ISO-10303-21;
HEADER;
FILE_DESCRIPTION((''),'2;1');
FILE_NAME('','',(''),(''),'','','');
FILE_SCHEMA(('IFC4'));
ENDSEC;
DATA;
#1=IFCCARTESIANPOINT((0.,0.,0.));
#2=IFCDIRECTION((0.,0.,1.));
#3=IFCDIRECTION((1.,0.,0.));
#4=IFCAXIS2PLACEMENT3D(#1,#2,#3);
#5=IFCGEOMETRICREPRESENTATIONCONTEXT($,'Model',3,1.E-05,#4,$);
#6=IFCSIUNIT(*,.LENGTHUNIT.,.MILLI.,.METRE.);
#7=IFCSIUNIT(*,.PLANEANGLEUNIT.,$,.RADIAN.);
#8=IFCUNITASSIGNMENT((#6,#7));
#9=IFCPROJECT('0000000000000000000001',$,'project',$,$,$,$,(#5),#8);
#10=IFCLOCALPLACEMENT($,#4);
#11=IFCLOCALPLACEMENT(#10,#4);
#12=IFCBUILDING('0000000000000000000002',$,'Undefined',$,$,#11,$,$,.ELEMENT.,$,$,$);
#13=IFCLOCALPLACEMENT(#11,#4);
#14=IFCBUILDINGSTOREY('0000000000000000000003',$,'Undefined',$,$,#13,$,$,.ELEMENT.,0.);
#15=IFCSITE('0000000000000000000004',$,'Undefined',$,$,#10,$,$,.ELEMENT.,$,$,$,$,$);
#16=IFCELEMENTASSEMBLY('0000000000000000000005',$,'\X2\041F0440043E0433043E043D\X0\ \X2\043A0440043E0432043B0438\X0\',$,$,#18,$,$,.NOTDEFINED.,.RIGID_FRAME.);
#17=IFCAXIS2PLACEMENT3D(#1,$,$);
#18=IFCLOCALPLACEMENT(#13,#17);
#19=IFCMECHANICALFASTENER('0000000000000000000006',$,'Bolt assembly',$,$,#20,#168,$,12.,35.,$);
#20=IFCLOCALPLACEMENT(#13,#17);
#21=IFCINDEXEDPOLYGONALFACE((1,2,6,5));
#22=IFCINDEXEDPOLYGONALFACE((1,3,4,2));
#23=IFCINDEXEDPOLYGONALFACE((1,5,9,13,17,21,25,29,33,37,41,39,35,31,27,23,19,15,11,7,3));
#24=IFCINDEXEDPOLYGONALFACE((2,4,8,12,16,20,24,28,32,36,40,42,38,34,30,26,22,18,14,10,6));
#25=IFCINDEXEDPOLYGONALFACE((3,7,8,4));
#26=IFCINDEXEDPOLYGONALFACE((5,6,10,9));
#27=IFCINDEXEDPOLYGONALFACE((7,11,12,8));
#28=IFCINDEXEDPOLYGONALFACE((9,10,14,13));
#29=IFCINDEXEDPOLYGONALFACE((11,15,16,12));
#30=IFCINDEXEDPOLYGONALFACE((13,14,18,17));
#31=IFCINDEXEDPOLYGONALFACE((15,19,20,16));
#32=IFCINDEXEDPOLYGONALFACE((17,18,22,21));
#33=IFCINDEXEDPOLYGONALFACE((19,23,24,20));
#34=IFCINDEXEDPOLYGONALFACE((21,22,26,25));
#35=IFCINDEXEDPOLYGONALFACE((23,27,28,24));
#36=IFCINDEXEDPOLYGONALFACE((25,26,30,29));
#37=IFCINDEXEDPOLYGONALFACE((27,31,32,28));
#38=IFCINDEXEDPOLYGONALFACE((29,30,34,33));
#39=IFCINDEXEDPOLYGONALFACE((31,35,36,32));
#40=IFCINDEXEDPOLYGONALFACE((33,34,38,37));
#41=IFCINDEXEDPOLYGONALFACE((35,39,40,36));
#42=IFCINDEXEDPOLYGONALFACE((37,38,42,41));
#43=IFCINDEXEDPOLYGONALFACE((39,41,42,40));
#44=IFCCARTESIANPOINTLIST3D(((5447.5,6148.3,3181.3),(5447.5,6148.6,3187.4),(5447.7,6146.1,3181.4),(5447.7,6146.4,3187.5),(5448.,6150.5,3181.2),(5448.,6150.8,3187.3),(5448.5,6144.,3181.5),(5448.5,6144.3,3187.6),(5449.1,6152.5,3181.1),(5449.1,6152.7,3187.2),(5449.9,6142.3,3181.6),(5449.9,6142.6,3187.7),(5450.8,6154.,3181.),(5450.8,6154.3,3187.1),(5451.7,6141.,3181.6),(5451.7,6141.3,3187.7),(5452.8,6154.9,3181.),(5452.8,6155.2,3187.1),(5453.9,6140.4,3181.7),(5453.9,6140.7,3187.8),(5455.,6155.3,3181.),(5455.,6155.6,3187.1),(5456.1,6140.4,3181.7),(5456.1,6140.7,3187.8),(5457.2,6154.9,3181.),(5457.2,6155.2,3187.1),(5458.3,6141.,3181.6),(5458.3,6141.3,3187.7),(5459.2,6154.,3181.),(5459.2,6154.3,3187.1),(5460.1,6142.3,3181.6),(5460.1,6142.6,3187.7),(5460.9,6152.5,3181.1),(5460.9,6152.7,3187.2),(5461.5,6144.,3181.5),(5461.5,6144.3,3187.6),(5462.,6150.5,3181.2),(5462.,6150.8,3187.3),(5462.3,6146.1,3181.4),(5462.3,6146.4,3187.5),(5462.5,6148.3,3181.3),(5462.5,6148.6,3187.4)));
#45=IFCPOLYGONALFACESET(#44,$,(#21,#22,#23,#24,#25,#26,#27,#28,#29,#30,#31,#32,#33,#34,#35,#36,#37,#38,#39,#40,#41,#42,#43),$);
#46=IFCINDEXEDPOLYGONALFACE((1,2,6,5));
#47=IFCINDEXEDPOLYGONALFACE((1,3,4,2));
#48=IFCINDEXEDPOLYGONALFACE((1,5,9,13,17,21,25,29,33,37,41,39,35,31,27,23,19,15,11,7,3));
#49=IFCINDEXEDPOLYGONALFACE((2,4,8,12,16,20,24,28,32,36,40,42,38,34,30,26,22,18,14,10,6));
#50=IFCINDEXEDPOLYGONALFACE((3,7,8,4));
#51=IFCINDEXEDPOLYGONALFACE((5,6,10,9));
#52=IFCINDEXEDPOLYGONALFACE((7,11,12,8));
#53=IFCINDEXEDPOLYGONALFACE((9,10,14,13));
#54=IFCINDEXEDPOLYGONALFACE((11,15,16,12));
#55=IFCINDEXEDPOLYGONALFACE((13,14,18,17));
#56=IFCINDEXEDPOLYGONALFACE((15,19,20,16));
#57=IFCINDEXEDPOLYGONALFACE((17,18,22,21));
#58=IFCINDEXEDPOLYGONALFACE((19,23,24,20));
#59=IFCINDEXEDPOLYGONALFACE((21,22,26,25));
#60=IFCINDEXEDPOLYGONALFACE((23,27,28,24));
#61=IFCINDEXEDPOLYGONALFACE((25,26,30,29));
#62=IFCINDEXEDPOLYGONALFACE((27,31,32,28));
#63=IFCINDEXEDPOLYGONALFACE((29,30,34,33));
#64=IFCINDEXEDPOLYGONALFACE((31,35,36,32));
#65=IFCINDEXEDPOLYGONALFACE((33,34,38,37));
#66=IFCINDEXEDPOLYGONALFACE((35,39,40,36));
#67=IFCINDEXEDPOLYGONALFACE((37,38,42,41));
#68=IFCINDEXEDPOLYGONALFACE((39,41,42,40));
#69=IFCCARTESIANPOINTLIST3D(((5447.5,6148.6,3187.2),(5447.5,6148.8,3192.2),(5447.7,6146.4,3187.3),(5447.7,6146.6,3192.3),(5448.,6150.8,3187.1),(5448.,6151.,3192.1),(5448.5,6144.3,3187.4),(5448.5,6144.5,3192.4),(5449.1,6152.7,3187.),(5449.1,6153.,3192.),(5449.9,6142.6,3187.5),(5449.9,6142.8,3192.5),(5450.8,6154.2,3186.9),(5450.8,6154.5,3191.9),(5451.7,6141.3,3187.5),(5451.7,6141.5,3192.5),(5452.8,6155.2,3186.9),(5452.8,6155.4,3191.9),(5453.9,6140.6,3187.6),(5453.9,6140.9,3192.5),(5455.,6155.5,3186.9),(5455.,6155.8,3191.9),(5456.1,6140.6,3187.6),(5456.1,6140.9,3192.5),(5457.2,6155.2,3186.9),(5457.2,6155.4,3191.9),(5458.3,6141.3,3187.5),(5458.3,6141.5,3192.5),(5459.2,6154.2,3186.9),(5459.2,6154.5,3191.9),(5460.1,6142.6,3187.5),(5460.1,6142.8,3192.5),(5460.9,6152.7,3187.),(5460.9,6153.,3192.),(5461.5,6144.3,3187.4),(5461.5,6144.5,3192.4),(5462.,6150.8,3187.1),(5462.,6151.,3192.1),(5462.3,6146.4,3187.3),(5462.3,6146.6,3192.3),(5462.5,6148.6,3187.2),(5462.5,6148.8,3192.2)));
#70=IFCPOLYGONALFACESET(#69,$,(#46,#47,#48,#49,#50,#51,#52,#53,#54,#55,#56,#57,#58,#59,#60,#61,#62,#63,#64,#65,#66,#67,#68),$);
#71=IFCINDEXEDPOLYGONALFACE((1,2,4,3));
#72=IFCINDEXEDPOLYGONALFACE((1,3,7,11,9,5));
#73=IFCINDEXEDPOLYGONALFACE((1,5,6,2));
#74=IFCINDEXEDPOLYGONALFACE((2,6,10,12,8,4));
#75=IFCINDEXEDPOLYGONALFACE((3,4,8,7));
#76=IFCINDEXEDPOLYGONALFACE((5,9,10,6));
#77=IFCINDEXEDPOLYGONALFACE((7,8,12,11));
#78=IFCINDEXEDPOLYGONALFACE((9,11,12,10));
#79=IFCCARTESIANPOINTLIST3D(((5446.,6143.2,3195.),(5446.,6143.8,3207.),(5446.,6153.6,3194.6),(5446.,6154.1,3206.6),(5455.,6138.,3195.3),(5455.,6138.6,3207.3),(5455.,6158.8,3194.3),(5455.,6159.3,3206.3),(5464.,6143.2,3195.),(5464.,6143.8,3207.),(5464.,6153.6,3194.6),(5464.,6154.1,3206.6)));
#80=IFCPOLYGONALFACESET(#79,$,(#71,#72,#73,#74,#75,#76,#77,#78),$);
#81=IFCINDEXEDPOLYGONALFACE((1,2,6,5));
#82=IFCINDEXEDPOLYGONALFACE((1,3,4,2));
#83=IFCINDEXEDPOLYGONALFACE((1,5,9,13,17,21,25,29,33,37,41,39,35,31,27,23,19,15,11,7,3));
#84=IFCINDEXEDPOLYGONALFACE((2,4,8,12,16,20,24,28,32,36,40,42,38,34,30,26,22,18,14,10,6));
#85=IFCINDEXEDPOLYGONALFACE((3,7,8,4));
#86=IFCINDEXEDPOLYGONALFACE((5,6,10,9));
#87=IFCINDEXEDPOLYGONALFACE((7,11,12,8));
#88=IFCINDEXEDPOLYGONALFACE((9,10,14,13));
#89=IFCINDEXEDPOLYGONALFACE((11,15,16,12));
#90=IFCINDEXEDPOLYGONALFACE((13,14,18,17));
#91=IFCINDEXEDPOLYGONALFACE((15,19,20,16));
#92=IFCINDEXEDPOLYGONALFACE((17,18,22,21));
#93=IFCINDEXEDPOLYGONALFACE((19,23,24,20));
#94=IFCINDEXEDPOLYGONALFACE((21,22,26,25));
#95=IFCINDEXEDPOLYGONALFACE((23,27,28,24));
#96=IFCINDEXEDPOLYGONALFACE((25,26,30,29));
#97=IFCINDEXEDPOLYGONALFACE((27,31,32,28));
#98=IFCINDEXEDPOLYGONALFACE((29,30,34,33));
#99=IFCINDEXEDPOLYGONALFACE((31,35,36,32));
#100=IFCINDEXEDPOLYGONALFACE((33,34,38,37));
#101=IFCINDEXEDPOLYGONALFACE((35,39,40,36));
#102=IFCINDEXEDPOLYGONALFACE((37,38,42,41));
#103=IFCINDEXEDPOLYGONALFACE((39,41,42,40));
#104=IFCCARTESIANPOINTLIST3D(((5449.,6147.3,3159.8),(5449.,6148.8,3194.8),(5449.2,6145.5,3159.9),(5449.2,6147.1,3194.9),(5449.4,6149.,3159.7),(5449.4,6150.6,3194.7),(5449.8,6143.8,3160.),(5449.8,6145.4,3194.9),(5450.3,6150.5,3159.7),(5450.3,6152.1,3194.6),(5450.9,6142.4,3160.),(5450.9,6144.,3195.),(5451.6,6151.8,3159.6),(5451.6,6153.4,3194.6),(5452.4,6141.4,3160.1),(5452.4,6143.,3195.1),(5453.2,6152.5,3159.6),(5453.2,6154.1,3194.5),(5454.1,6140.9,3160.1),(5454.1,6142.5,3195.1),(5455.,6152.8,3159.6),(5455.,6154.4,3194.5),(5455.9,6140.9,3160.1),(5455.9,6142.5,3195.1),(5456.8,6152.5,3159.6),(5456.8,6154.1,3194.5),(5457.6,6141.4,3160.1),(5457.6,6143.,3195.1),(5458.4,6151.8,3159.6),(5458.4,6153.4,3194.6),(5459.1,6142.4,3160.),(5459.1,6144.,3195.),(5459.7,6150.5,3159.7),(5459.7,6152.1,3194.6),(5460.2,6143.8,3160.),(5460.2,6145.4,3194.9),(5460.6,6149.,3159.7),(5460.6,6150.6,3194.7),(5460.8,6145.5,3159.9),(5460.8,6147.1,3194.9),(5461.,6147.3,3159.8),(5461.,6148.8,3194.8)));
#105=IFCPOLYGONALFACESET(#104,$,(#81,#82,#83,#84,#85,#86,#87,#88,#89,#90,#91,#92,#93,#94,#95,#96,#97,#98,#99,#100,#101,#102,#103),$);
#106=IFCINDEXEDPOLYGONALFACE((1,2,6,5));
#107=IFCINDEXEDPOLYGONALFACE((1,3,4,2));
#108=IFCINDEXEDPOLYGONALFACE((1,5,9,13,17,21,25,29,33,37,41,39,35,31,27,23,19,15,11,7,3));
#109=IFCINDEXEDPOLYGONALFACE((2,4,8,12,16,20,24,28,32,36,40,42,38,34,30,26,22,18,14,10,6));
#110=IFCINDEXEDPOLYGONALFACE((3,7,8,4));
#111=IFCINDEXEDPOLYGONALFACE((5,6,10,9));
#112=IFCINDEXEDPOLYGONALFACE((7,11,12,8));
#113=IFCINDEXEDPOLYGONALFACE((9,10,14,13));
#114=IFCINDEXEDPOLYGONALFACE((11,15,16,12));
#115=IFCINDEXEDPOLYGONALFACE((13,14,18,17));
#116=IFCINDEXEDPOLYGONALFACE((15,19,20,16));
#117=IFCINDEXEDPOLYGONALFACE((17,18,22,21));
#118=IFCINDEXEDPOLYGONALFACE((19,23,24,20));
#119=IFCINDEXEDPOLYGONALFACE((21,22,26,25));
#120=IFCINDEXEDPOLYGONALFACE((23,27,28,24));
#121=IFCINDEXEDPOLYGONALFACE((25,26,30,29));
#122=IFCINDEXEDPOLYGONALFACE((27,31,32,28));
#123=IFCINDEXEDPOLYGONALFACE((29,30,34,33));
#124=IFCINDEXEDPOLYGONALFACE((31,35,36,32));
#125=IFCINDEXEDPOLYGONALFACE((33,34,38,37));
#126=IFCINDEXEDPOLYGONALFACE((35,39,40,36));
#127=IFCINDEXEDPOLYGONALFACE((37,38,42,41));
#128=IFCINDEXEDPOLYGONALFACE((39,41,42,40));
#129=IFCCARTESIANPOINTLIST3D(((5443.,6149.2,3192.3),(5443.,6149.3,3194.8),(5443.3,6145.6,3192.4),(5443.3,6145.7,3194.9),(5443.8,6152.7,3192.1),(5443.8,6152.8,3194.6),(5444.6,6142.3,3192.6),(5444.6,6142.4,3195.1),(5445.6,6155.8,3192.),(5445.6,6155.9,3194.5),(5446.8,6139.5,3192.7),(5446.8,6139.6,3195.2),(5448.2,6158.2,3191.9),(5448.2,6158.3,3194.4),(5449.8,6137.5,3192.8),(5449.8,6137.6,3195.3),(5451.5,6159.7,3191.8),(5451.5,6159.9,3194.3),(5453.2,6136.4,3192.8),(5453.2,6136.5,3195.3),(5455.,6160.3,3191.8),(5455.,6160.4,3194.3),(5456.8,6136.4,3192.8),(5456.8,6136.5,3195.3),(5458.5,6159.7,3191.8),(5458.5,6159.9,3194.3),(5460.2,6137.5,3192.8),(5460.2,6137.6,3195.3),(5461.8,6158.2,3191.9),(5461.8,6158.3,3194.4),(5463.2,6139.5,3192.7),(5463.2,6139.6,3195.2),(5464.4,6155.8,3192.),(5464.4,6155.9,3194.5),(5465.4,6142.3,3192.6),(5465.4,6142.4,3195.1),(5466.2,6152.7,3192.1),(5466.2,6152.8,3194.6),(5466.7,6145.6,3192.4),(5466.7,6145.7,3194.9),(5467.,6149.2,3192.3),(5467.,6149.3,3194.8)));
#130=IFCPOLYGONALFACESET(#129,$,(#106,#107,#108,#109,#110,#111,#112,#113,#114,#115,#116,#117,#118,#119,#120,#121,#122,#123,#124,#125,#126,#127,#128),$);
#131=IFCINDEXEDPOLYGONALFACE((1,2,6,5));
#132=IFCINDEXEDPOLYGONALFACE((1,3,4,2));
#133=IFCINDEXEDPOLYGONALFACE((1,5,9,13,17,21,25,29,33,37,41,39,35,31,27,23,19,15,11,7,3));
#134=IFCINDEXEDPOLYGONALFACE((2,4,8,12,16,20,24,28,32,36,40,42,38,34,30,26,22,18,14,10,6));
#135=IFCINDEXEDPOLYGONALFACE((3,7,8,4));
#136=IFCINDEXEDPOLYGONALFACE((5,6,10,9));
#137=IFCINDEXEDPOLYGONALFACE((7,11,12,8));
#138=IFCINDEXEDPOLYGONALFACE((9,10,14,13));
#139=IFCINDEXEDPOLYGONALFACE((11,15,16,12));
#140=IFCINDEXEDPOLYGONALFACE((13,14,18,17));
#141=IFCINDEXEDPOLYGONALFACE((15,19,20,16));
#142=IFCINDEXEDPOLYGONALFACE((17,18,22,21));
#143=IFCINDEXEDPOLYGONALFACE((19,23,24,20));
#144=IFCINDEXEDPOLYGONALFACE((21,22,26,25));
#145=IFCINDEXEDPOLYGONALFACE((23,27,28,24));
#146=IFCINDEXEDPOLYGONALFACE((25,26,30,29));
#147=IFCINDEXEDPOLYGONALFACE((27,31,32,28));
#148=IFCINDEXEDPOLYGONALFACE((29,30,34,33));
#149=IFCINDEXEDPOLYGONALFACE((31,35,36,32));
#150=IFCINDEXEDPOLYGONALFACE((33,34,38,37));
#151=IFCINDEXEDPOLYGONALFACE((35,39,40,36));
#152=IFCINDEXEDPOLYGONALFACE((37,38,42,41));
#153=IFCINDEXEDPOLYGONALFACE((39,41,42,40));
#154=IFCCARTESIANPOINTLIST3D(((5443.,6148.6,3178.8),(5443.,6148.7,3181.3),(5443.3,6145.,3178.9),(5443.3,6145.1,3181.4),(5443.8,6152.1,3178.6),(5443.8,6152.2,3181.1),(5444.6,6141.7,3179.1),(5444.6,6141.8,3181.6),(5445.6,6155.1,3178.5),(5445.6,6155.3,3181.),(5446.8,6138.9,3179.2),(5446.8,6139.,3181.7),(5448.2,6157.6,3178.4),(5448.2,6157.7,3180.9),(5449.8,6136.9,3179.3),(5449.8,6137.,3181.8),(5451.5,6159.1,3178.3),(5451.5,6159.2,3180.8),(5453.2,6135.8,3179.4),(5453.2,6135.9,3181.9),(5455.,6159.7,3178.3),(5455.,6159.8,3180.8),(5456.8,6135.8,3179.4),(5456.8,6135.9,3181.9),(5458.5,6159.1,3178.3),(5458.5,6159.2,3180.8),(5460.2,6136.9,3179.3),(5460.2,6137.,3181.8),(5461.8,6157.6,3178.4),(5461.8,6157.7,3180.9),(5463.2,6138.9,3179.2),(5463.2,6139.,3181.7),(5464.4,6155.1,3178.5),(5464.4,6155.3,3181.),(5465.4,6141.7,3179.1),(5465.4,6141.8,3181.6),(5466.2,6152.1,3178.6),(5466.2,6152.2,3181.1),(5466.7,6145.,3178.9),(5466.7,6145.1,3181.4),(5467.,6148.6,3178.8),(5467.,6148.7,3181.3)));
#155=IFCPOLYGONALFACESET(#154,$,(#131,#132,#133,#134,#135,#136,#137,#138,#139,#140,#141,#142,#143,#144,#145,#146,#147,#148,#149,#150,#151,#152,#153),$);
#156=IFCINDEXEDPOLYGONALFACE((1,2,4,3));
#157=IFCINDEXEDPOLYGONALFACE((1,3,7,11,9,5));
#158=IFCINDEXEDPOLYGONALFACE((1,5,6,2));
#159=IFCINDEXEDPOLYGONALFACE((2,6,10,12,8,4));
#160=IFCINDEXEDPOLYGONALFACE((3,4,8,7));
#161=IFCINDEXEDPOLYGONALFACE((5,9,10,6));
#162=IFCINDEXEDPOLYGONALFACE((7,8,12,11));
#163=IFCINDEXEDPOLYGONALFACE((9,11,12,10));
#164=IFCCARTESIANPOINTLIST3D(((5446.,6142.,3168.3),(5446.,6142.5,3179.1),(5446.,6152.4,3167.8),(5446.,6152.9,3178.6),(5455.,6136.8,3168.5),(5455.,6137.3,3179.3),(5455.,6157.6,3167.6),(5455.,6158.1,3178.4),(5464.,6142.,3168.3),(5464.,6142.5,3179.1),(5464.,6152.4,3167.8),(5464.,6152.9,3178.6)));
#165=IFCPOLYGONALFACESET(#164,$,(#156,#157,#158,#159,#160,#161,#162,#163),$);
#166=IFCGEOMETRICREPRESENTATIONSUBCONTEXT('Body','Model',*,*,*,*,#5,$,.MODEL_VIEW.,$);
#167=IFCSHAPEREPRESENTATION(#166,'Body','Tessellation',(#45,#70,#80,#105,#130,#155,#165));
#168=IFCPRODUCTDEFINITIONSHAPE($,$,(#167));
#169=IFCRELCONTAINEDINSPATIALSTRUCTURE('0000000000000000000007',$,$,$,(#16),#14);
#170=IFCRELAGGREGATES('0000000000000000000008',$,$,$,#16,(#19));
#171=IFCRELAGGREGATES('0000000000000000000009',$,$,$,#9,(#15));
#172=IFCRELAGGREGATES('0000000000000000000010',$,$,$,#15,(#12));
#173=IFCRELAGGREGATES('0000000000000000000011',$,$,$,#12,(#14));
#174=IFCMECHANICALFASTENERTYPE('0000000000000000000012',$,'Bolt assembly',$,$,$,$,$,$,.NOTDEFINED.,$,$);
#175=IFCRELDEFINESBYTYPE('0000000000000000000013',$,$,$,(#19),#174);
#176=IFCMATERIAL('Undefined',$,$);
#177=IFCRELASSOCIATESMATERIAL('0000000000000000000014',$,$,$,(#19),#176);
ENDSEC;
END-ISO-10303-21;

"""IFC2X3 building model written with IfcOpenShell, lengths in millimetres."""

from ifc_helpers import new_model, si_unit, frame, origin_with_axes, origin_2d_with_axis, place, context, subcontext, project, spatial, polyline, circle, outline, extrude, source, transform, mapped, material, type_object, element, aggregate, save


model = new_model("IFC2X3")

# Units and contexts
model_context = context("Model", 3, precision=1e-05, world=origin_with_axes())
body_context = subcontext(model_context, "Body", "Model", "MODEL_VIEW")
ifc_project = project(units=[si_unit("LENGTHUNIT", "METRE", prefix="MILLI"), si_unit("PLANEANGLEUNIT", "RADIAN")], contexts=[model_context])

# Site, building, storey
site_placement = place(None, origin_with_axes())
site = spatial("IfcSite", under=ifc_project, at=site_placement, Name="Undefined", CompositionType="ELEMENT")
building_placement = place(site_placement, origin_with_axes())
building = spatial("IfcBuilding", under=site, at=building_placement, Name="Undefined", CompositionType="ELEMENT")
storey_placement = place(building_placement, origin_with_axes())
storey = spatial("IfcBuildingStorey", under=building, at=storey_placement, Name="Undefined", CompositionType="ELEMENT", Elevation=0.0)

# Element assembly
assembly_1_placement = place(storey_placement, origin_with_axes())
assembly_1 = element("IfcElementAssembly", 1, at=assembly_1_placement, inside=storey, Name="Прогон кровли", AssemblyPlace="NOTDEFINED", PredefinedType="RIGID_FRAME")

# Mechanical fastener
ifc_material_1 = material(Name="Undefined")
mechanical_fastener_type = type_object("IfcMechanicalFastenerType", Name="Bolt assembly")
shared_shape_1 = source(origin_with_axes(), body_context, "Body", "SweptSolid", [
    extrude(circle(Radius=7.5, at=origin_2d_with_axis()), frame((0.0, -0.1, 0.0), z_axis=(0.0, 1.0, 0.0), x_axis=(1.0, 0.0, 0.0)), (0.0, 0.0, 1.0), 6.1),
    extrude(circle(Radius=7.5, at=origin_2d_with_axis()), frame((0.0, -4.9, 0.0), z_axis=(0.0, 1.0, 0.0), x_axis=(1.0, 0.0, 0.0)), (0.0, 0.0, 1.0), 5.0),
    extrude(outline(polyline([(10.4, 0.0), (5.2, 9.0), (-5.2, 9.0), (-10.4, 0.0), (-5.2, -9.0), (5.2, -9.0), (10.4, 0.0)])), frame((0.0, -19.5, 0.0), z_axis=(0.0, 1.0, 0.0), x_axis=(1.0, 0.0, 0.0)), (0.0, 0.0, 1.0), 12.0),
    extrude(circle(Radius=6.0, at=origin_2d_with_axis()), frame((0.0, -7.5, 0.0), z_axis=(0.0, 1.0, 0.0), x_axis=(1.0, 0.0, 0.0)), (0.0, 0.0, 1.0), 35.0),
    extrude(circle(Radius=12.0, at=origin_2d_with_axis()), frame((0.0, -7.5, 0.0), z_axis=(0.0, 1.0, 0.0), x_axis=(1.0, 0.0, 0.0)), (0.0, 0.0, 1.0), 2.5),
    extrude(circle(Radius=12.0, at=origin_2d_with_axis()), frame((0.0, 6.0, 0.0), z_axis=(0.0, 1.0, 0.0), x_axis=(1.0, 0.0, 0.0)), (0.0, 0.0, 1.0), 2.5),
    extrude(outline(polyline([(10.4, 0.0), (5.2, 9.0), (-5.2, 9.0), (-10.4, 0.0), (-5.2, -9.0), (5.2, -9.0), (10.4, 0.0)])), frame((0.0, 8.5, 0.0), z_axis=(0.0, 1.0, 0.0), x_axis=(1.0, 0.0, 0.0)), (0.0, 0.0, 1.0), 10.8),
])
mechanical_fastener_1_placement = place(assembly_1_placement, frame((5455.0, 6148.1, 3187.3), z_axis=(-1.0, 0.0, 0.0), x_axis=(0.0, 0.998969, -0.045408)))
mechanical_fastener_1 = element("IfcMechanicalFastener", 2, at=mechanical_fastener_1_placement, type_object=mechanical_fastener_type, material=ifc_material_1, Name="Bolt assembly", NominalDiameter=12.0, NominalLength=35.0, context=body_context, shape_type="MappedRepresentation", body=[
    mapped(shared_shape_1, transform((0.0, 0.0, 0.0))),
])
aggregate(assembly_1, [mechanical_fastener_1])

save(model, "model.ifc")
